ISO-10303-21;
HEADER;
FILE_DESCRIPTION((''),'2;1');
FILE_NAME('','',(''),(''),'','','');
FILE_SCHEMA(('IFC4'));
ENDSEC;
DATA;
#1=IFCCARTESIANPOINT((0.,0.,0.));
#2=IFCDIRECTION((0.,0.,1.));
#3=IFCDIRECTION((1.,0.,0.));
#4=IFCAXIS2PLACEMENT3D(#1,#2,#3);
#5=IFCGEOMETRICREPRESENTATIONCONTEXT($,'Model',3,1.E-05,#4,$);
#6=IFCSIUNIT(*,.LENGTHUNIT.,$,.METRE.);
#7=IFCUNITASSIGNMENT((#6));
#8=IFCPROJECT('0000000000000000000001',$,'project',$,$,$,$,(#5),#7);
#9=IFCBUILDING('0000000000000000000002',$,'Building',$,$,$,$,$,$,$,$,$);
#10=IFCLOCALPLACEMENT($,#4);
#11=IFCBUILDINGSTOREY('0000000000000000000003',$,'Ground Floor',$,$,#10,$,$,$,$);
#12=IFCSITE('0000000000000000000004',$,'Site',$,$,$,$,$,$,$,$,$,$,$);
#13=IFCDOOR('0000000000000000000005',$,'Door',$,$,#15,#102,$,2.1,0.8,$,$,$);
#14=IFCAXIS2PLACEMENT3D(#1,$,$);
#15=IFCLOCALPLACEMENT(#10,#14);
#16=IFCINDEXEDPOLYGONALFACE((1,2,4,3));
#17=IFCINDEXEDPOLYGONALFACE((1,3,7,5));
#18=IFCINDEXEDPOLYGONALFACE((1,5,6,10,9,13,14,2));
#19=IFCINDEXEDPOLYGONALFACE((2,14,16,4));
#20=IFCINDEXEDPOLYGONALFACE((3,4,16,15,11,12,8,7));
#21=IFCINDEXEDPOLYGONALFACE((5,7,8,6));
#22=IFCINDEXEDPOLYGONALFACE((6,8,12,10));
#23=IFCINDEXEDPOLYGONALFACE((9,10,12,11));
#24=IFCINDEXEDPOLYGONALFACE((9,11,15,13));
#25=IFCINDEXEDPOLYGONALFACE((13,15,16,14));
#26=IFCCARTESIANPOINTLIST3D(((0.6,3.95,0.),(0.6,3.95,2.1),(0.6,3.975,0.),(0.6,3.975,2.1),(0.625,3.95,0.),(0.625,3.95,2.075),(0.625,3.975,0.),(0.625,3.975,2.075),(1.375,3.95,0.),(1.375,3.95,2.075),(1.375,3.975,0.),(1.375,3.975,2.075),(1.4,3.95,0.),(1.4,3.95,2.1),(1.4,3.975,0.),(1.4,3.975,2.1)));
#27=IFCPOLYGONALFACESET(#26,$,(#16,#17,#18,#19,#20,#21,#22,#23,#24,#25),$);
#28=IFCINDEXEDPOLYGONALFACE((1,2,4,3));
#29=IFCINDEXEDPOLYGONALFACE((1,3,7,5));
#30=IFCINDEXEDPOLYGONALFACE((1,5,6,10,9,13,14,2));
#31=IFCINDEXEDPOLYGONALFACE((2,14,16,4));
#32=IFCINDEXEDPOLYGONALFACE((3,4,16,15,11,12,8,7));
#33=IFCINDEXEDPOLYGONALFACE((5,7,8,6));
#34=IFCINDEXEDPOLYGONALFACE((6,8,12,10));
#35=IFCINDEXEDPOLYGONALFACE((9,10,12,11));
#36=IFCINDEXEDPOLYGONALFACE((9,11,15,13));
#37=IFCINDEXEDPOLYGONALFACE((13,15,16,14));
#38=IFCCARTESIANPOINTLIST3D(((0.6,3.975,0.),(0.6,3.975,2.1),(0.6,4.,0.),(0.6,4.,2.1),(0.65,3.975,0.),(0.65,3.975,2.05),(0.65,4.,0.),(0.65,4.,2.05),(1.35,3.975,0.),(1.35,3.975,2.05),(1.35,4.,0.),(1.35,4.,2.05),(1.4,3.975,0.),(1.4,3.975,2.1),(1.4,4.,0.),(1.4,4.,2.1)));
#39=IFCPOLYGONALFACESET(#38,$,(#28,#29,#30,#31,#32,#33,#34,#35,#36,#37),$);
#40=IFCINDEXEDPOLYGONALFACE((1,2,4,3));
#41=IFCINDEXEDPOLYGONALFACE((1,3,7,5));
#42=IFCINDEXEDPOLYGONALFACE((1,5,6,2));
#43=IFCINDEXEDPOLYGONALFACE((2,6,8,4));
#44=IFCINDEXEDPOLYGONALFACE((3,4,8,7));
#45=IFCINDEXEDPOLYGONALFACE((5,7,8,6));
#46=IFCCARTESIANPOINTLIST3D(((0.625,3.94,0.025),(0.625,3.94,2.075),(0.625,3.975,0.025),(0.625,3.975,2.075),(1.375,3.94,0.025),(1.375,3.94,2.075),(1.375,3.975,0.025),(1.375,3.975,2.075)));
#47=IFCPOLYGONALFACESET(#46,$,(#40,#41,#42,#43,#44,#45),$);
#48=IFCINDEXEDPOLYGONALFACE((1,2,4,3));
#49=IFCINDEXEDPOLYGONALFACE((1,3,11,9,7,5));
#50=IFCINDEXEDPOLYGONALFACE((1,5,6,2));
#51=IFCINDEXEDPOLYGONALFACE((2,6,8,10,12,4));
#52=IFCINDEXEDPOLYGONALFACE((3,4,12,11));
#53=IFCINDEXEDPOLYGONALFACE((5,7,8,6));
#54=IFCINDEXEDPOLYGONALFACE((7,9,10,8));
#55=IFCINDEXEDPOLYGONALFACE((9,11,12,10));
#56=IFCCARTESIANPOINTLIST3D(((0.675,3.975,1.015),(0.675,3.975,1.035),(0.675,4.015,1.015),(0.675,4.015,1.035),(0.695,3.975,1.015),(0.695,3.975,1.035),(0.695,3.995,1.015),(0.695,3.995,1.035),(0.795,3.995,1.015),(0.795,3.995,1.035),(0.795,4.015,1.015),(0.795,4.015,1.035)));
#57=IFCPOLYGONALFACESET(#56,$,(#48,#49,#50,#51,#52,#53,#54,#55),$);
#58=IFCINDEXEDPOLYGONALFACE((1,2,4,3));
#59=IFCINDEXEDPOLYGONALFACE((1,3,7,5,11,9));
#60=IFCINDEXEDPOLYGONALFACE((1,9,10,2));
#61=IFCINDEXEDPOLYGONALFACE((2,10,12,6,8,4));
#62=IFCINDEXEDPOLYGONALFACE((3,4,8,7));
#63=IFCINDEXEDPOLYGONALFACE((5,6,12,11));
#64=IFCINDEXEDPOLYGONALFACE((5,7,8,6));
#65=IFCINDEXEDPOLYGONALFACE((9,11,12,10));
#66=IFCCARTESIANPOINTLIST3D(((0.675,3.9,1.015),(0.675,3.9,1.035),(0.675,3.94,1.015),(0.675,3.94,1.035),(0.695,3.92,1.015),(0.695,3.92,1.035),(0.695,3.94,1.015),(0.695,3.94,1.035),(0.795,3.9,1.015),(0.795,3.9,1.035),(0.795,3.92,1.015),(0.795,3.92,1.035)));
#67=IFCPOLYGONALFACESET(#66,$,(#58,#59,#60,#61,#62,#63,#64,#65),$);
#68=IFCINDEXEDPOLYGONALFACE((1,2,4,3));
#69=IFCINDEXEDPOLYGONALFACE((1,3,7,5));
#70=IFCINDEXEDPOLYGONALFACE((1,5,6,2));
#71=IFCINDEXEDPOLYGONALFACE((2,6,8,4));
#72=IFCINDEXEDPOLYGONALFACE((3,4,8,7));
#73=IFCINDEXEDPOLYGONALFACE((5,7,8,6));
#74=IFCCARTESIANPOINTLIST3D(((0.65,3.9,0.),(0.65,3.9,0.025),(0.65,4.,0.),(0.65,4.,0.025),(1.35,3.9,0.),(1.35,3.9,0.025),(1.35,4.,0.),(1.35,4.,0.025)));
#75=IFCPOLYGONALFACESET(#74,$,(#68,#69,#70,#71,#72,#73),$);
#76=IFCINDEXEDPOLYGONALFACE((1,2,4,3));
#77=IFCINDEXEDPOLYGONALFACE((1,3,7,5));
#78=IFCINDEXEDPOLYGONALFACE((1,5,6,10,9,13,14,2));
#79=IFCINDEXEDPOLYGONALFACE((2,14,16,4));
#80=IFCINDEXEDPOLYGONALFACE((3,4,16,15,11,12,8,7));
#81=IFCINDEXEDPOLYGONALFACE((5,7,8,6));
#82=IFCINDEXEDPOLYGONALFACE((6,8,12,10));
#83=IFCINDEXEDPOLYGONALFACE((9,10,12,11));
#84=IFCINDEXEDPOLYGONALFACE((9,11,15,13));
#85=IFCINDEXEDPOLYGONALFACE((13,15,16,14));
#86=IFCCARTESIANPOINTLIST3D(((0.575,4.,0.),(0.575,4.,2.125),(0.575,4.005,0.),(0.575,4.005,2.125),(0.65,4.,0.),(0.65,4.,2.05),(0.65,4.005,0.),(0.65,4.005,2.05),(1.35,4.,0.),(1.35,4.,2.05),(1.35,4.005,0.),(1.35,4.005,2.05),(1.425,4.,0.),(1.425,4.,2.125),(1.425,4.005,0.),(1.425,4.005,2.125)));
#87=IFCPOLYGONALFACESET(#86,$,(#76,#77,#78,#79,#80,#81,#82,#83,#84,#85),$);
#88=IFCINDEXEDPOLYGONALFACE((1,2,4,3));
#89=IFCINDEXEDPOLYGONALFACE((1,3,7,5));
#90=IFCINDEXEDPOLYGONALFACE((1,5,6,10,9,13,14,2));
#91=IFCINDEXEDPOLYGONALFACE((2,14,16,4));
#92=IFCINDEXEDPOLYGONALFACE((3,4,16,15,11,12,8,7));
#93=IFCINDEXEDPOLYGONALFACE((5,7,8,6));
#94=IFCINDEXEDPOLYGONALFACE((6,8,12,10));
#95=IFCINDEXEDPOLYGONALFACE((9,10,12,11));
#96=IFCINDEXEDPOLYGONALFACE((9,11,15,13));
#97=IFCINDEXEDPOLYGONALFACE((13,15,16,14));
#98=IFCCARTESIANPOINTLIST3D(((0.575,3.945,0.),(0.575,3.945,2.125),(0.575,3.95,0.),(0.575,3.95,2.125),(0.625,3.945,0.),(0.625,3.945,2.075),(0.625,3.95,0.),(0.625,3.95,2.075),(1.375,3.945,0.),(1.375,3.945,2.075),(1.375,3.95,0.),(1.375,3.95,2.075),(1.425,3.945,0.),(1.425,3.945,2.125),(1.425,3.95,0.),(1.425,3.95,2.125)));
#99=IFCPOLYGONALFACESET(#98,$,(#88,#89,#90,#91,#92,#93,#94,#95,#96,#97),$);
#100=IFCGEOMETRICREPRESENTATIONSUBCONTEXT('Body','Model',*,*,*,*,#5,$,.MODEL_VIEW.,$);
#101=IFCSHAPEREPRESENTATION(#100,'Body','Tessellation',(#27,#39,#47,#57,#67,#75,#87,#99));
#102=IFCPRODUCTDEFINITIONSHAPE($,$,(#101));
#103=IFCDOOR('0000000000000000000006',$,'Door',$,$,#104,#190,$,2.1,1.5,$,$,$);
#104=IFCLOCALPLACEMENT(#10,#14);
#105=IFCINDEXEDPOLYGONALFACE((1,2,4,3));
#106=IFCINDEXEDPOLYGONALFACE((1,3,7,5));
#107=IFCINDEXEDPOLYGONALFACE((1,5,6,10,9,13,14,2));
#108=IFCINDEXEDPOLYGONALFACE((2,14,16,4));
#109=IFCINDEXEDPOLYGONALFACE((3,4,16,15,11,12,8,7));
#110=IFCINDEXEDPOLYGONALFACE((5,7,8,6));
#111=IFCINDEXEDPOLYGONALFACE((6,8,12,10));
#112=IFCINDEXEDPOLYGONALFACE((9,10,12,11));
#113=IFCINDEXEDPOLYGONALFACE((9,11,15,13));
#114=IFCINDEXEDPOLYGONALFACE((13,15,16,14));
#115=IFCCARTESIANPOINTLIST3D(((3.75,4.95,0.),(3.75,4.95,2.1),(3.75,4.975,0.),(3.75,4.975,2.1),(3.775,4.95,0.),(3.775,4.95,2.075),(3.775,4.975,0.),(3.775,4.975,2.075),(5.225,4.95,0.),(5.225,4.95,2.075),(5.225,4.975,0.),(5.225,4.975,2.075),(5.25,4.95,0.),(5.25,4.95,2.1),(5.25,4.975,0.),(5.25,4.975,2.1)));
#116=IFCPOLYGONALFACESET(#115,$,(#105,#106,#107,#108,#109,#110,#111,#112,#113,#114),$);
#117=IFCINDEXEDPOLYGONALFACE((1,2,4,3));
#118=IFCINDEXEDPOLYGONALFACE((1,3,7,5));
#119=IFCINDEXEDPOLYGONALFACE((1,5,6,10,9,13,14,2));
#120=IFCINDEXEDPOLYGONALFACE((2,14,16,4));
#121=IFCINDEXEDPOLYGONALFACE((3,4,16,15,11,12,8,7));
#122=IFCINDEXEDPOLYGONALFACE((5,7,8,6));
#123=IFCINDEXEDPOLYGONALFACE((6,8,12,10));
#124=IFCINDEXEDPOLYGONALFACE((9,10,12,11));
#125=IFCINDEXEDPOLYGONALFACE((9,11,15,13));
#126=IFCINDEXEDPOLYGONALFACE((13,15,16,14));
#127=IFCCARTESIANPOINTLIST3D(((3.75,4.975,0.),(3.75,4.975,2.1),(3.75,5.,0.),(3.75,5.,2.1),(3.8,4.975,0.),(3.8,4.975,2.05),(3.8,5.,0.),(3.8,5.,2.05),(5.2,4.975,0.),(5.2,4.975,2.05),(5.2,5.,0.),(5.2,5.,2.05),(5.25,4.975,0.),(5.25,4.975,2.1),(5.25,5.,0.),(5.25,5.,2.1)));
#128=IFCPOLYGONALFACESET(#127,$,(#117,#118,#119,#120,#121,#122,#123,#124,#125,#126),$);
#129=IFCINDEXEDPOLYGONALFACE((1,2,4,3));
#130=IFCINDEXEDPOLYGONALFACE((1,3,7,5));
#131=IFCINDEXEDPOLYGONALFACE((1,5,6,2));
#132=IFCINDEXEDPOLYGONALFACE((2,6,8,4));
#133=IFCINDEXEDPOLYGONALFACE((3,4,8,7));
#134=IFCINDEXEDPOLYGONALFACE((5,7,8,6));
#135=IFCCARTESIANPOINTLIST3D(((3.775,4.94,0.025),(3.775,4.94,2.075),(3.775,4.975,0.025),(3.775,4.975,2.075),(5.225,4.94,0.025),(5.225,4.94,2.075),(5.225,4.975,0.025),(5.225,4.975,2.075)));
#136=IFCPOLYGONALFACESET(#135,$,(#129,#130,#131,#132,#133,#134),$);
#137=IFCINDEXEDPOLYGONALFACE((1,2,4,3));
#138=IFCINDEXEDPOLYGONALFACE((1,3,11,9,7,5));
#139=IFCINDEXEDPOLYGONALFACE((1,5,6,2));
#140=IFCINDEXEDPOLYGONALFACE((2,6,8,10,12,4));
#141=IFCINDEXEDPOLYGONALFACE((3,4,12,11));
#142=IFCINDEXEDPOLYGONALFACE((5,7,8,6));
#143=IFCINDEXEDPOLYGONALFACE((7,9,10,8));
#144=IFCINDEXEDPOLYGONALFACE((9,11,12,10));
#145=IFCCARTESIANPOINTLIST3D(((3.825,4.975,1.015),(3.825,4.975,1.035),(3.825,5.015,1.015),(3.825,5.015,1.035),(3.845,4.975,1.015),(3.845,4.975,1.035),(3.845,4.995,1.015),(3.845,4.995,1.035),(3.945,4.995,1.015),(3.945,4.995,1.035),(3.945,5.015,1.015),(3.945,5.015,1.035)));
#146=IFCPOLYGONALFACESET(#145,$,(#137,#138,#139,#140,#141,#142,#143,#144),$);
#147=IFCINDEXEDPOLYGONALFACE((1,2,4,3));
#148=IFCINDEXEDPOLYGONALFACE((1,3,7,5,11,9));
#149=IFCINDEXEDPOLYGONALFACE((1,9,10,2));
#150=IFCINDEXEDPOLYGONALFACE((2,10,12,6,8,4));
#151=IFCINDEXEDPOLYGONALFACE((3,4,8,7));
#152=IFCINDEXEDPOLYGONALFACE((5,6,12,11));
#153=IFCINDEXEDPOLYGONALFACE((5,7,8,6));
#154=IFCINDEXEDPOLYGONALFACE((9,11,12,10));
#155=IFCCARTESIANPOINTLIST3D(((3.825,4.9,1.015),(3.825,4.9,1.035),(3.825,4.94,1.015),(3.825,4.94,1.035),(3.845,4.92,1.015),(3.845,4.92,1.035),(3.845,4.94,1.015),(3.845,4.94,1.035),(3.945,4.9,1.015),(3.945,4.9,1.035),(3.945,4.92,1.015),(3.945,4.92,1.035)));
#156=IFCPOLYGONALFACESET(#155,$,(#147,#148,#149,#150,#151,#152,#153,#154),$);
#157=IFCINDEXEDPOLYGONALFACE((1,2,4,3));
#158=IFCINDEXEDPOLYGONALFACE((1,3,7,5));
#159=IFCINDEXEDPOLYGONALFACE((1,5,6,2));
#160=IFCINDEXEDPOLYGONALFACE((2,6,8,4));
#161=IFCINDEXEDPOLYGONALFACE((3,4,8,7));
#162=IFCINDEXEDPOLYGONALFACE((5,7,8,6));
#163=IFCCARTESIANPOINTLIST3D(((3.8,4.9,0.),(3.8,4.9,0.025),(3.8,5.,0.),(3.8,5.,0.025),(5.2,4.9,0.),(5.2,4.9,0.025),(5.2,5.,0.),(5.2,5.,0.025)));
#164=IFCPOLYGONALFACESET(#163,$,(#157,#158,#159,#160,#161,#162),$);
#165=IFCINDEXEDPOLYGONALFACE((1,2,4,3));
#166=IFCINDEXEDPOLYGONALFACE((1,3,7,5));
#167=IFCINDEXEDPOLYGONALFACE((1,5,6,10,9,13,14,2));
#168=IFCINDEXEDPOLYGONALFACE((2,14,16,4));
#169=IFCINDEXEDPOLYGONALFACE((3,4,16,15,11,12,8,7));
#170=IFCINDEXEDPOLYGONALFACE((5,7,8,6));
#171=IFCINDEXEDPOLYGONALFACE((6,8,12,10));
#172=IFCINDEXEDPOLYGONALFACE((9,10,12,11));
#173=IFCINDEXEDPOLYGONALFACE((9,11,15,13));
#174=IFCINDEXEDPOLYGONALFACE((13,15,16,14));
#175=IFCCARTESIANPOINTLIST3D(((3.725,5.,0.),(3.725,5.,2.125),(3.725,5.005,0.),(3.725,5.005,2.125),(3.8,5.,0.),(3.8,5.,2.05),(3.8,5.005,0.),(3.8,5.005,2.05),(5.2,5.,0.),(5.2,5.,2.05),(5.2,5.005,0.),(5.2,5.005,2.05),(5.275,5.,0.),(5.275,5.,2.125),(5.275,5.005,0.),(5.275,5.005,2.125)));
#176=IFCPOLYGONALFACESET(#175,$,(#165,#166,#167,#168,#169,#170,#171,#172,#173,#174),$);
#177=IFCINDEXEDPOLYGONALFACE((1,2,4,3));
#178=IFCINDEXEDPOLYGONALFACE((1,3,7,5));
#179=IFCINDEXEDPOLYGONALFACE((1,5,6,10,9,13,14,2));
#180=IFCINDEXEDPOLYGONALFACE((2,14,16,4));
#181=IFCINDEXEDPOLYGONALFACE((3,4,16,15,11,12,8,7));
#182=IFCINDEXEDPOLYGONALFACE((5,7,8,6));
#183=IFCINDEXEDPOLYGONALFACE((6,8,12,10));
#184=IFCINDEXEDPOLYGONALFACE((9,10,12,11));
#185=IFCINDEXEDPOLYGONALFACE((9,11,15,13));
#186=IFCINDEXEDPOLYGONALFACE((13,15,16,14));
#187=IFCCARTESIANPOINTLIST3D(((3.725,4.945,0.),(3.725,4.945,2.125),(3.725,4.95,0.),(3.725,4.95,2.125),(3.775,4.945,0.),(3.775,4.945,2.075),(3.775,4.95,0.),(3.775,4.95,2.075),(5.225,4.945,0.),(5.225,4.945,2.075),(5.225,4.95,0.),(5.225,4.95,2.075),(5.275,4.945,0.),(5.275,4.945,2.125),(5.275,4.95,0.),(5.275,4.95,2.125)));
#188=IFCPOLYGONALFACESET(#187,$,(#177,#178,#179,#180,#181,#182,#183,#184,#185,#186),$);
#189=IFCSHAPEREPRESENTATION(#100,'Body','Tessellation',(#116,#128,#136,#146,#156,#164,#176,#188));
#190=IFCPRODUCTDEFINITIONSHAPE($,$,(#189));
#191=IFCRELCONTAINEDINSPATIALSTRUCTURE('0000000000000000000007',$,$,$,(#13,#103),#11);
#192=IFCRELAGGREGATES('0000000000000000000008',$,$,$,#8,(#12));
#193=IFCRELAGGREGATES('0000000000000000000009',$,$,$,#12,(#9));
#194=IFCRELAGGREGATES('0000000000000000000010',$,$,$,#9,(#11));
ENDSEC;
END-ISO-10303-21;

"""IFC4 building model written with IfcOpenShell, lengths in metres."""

from ifc_helpers import new_model, si_unit, frame, origin_with_axes, place, context, subcontext, project, spatial, line, indexed_curve, outline, extrude, element, save


model = new_model("IFC4")

# Units and contexts
model_context = context("Model", 3, precision=1e-05, world=origin_with_axes())
body_context = subcontext(model_context, "Body", "Model", "MODEL_VIEW")
ifc_project = project(units=[si_unit("LENGTHUNIT", "METRE")], contexts=[model_context])

# Site, building, storey
site = spatial("IfcSite", under=ifc_project, Name="Site")
building = spatial("IfcBuilding", under=site, Name="Building")
storey_placement = place(None, origin_with_axes())
storey = spatial("IfcBuildingStorey", under=building, at=storey_placement, Name="Ground Floor")

# Doors
door_1_placement = place(storey_placement, frame((1.4, 4.0, 0.0), z_axis=(0.0, 0.0, 1.0), x_axis=(-1.0, 0.0, 0.0)))
element("IfcDoor", 1, at=door_1_placement, inside=storey, Name="Door", OverallHeight=2.1, OverallWidth=0.8, context=body_context, shape_type="SweptSolid", body=[
    extrude(outline(indexed_curve([(0.0, 0.0), (0.0, 2.1), (0.8, 2.1), (0.8, 0.0), (0.775, 0.0), (0.775, 2.075), (0.025, 2.075), (0.025, 0.0)], segments=[line(1, 2, 3, 4, 5, 6, 7, 8, 1)])), frame((0.0, 0.025, 0.0), z_axis=(0.0, -1.0, 0.0), x_axis=(1.0, 0.0, 0.0)), (0.0, 0.0, -1.0), 0.025),
    extrude(outline(indexed_curve([(0.0, 0.0), (0.0, 2.1), (0.8, 2.1), (0.8, 0.0), (0.75, 0.0), (0.75, 2.05), (0.05, 2.05), (0.05, 0.0)], segments=[line(1, 2, 3, 4, 5, 6, 7, 8, 1)])), frame((0.0, 0.0, 0.0), z_axis=(0.0, -1.0, 0.0), x_axis=(1.0, 0.0, 0.0)), (0.0, 0.0, -1.0), 0.025),
    extrude(outline(indexed_curve([(0.0, 0.0), (0.75, 0.0), (0.75, 0.035), (0.0, 0.035)], segments=[line(1, 2, 3, 4, 1)])), frame((0.025, 0.025, 0.025), z_axis=(0.0, 0.0, 1.0), x_axis=(1.0, 0.0, 0.0)), (0.0, 0.0, 1.0), 2.05),
    extrude(outline(indexed_curve([(0.0, 0.0), (0.0, -0.04), (-0.12, -0.04), (-0.12, -0.02), (-0.02, -0.02), (-0.02, 0.0)], segments=[line(1, 2, 3, 4, 5, 6, 1)])), frame((0.725, 0.025, 1.015), z_axis=(0.0, 0.0, 1.0), x_axis=(1.0, 0.0, 0.0)), (0.0, 0.0, 1.0), 0.02),
    extrude(outline(indexed_curve([(0.0, 0.0), (0.0, 0.04), (-0.12, 0.04), (-0.12, 0.02), (-0.02, 0.02), (-0.02, 0.0)], segments=[line(1, 2, 3, 4, 5, 6, 1)])), frame((0.725, 0.06, 1.015), z_axis=(0.0, 0.0, 1.0), x_axis=(1.0, 0.0, 0.0)), (0.0, 0.0, 1.0), 0.02),
    extrude(outline(indexed_curve([(0.0, 0.0), (0.7, 0.0), (0.7, 0.1), (0.0, 0.1)], segments=[line(1, 2, 3, 4, 1)])), frame((0.05, 0.0, 0.0), z_axis=(0.0, 0.0, 1.0), x_axis=(1.0, 0.0, 0.0)), (0.0, 0.0, 1.0), 0.025),
    extrude(outline(indexed_curve([(0.0, 0.0), (0.0, 2.125), (0.85, 2.125), (0.85, 0.0), (0.775, 0.0), (0.775, 2.05), (0.075, 2.05), (0.075, 0.0)], segments=[line(1, 2, 3, 4, 5, 6, 7, 8, 1)])), frame((-0.025, -0.005, 0.0), z_axis=(0.0, -1.0, 0.0), x_axis=(1.0, 0.0, 0.0)), (0.0, 0.0, -1.0), 0.005),
    extrude(outline(indexed_curve([(0.0, 0.0), (0.0, 2.125), (0.85, 2.125), (0.85, 0.0), (0.8, 0.0), (0.8, 2.075), (0.05, 2.075), (0.05, 0.0)], segments=[line(1, 2, 3, 4, 5, 6, 7, 8, 1)])), frame((-0.025, 0.05, 0.0), z_axis=(0.0, -1.0, 0.0), x_axis=(1.0, 0.0, 0.0)), (0.0, 0.0, -1.0), 0.005),
])
door_2_placement = place(storey_placement, frame((5.25, 5.0, 0.0), z_axis=(0.0, 0.0, 1.0), x_axis=(-1.0, 0.0, 0.0)))
element("IfcDoor", 2, at=door_2_placement, inside=storey, Name="Door", OverallHeight=2.1, OverallWidth=1.5, context=body_context, shape_type="SweptSolid", body=[
    extrude(outline(indexed_curve([(0.0, 0.0), (0.0, 2.1), (1.5, 2.1), (1.5, 0.0), (1.475, 0.0), (1.475, 2.075), (0.025, 2.075), (0.025, 0.0)], segments=[line(1, 2, 3, 4, 5, 6, 7, 8, 1)])), frame((0.0, 0.025, 0.0), z_axis=(0.0, -1.0, 0.0), x_axis=(1.0, 0.0, 0.0)), (0.0, 0.0, -1.0), 0.025),
    extrude(outline(indexed_curve([(0.0, 0.0), (0.0, 2.1), (1.5, 2.1), (1.5, 0.0), (1.45, 0.0), (1.45, 2.05), (0.05, 2.05), (0.05, 0.0)], segments=[line(1, 2, 3, 4, 5, 6, 7, 8, 1)])), frame((0.0, 0.0, 0.0), z_axis=(0.0, -1.0, 0.0), x_axis=(1.0, 0.0, 0.0)), (0.0, 0.0, -1.0), 0.025),
    extrude(outline(indexed_curve([(0.0, 0.0), (1.45, 0.0), (1.45, 0.035), (0.0, 0.035)], segments=[line(1, 2, 3, 4, 1)])), frame((0.025, 0.025, 0.025), z_axis=(0.0, 0.0, 1.0), x_axis=(1.0, 0.0, 0.0)), (0.0, 0.0, 1.0), 2.05),
    extrude(outline(indexed_curve([(0.0, 0.0), (0.0, -0.04), (-0.12, -0.04), (-0.12, -0.02), (-0.02, -0.02), (-0.02, 0.0)], segments=[line(1, 2, 3, 4, 5, 6, 1)])), frame((1.425, 0.025, 1.015), z_axis=(0.0, 0.0, 1.0), x_axis=(1.0, 0.0, 0.0)), (0.0, 0.0, 1.0), 0.02),
    extrude(outline(indexed_curve([(0.0, 0.0), (0.0, 0.04), (-0.12, 0.04), (-0.12, 0.02), (-0.02, 0.02), (-0.02, 0.0)], segments=[line(1, 2, 3, 4, 5, 6, 1)])), frame((1.425, 0.06, 1.015), z_axis=(0.0, 0.0, 1.0), x_axis=(1.0, 0.0, 0.0)), (0.0, 0.0, 1.0), 0.02),
    extrude(outline(indexed_curve([(0.0, 0.0), (1.4, 0.0), (1.4, 0.1), (0.0, 0.1)], segments=[line(1, 2, 3, 4, 1)])), frame((0.05, 0.0, 0.0), z_axis=(0.0, 0.0, 1.0), x_axis=(1.0, 0.0, 0.0)), (0.0, 0.0, 1.0), 0.025),
    extrude(outline(indexed_curve([(0.0, 0.0), (0.0, 2.125), (1.55, 2.125), (1.55, 0.0), (1.475, 0.0), (1.475, 2.05), (0.075, 2.05), (0.075, 0.0)], segments=[line(1, 2, 3, 4, 5, 6, 7, 8, 1)])), frame((-0.025, -0.005, 0.0), z_axis=(0.0, -1.0, 0.0), x_axis=(1.0, 0.0, 0.0)), (0.0, 0.0, -1.0), 0.005),
    extrude(outline(indexed_curve([(0.0, 0.0), (0.0, 2.125), (1.55, 2.125), (1.55, 0.0), (1.5, 0.0), (1.5, 2.075), (0.05, 2.075), (0.05, 0.0)], segments=[line(1, 2, 3, 4, 5, 6, 7, 8, 1)])), frame((-0.025, 0.05, 0.0), z_axis=(0.0, -1.0, 0.0), x_axis=(1.0, 0.0, 0.0)), (0.0, 0.0, -1.0), 0.005),
])

save(model, "model.ifc")
